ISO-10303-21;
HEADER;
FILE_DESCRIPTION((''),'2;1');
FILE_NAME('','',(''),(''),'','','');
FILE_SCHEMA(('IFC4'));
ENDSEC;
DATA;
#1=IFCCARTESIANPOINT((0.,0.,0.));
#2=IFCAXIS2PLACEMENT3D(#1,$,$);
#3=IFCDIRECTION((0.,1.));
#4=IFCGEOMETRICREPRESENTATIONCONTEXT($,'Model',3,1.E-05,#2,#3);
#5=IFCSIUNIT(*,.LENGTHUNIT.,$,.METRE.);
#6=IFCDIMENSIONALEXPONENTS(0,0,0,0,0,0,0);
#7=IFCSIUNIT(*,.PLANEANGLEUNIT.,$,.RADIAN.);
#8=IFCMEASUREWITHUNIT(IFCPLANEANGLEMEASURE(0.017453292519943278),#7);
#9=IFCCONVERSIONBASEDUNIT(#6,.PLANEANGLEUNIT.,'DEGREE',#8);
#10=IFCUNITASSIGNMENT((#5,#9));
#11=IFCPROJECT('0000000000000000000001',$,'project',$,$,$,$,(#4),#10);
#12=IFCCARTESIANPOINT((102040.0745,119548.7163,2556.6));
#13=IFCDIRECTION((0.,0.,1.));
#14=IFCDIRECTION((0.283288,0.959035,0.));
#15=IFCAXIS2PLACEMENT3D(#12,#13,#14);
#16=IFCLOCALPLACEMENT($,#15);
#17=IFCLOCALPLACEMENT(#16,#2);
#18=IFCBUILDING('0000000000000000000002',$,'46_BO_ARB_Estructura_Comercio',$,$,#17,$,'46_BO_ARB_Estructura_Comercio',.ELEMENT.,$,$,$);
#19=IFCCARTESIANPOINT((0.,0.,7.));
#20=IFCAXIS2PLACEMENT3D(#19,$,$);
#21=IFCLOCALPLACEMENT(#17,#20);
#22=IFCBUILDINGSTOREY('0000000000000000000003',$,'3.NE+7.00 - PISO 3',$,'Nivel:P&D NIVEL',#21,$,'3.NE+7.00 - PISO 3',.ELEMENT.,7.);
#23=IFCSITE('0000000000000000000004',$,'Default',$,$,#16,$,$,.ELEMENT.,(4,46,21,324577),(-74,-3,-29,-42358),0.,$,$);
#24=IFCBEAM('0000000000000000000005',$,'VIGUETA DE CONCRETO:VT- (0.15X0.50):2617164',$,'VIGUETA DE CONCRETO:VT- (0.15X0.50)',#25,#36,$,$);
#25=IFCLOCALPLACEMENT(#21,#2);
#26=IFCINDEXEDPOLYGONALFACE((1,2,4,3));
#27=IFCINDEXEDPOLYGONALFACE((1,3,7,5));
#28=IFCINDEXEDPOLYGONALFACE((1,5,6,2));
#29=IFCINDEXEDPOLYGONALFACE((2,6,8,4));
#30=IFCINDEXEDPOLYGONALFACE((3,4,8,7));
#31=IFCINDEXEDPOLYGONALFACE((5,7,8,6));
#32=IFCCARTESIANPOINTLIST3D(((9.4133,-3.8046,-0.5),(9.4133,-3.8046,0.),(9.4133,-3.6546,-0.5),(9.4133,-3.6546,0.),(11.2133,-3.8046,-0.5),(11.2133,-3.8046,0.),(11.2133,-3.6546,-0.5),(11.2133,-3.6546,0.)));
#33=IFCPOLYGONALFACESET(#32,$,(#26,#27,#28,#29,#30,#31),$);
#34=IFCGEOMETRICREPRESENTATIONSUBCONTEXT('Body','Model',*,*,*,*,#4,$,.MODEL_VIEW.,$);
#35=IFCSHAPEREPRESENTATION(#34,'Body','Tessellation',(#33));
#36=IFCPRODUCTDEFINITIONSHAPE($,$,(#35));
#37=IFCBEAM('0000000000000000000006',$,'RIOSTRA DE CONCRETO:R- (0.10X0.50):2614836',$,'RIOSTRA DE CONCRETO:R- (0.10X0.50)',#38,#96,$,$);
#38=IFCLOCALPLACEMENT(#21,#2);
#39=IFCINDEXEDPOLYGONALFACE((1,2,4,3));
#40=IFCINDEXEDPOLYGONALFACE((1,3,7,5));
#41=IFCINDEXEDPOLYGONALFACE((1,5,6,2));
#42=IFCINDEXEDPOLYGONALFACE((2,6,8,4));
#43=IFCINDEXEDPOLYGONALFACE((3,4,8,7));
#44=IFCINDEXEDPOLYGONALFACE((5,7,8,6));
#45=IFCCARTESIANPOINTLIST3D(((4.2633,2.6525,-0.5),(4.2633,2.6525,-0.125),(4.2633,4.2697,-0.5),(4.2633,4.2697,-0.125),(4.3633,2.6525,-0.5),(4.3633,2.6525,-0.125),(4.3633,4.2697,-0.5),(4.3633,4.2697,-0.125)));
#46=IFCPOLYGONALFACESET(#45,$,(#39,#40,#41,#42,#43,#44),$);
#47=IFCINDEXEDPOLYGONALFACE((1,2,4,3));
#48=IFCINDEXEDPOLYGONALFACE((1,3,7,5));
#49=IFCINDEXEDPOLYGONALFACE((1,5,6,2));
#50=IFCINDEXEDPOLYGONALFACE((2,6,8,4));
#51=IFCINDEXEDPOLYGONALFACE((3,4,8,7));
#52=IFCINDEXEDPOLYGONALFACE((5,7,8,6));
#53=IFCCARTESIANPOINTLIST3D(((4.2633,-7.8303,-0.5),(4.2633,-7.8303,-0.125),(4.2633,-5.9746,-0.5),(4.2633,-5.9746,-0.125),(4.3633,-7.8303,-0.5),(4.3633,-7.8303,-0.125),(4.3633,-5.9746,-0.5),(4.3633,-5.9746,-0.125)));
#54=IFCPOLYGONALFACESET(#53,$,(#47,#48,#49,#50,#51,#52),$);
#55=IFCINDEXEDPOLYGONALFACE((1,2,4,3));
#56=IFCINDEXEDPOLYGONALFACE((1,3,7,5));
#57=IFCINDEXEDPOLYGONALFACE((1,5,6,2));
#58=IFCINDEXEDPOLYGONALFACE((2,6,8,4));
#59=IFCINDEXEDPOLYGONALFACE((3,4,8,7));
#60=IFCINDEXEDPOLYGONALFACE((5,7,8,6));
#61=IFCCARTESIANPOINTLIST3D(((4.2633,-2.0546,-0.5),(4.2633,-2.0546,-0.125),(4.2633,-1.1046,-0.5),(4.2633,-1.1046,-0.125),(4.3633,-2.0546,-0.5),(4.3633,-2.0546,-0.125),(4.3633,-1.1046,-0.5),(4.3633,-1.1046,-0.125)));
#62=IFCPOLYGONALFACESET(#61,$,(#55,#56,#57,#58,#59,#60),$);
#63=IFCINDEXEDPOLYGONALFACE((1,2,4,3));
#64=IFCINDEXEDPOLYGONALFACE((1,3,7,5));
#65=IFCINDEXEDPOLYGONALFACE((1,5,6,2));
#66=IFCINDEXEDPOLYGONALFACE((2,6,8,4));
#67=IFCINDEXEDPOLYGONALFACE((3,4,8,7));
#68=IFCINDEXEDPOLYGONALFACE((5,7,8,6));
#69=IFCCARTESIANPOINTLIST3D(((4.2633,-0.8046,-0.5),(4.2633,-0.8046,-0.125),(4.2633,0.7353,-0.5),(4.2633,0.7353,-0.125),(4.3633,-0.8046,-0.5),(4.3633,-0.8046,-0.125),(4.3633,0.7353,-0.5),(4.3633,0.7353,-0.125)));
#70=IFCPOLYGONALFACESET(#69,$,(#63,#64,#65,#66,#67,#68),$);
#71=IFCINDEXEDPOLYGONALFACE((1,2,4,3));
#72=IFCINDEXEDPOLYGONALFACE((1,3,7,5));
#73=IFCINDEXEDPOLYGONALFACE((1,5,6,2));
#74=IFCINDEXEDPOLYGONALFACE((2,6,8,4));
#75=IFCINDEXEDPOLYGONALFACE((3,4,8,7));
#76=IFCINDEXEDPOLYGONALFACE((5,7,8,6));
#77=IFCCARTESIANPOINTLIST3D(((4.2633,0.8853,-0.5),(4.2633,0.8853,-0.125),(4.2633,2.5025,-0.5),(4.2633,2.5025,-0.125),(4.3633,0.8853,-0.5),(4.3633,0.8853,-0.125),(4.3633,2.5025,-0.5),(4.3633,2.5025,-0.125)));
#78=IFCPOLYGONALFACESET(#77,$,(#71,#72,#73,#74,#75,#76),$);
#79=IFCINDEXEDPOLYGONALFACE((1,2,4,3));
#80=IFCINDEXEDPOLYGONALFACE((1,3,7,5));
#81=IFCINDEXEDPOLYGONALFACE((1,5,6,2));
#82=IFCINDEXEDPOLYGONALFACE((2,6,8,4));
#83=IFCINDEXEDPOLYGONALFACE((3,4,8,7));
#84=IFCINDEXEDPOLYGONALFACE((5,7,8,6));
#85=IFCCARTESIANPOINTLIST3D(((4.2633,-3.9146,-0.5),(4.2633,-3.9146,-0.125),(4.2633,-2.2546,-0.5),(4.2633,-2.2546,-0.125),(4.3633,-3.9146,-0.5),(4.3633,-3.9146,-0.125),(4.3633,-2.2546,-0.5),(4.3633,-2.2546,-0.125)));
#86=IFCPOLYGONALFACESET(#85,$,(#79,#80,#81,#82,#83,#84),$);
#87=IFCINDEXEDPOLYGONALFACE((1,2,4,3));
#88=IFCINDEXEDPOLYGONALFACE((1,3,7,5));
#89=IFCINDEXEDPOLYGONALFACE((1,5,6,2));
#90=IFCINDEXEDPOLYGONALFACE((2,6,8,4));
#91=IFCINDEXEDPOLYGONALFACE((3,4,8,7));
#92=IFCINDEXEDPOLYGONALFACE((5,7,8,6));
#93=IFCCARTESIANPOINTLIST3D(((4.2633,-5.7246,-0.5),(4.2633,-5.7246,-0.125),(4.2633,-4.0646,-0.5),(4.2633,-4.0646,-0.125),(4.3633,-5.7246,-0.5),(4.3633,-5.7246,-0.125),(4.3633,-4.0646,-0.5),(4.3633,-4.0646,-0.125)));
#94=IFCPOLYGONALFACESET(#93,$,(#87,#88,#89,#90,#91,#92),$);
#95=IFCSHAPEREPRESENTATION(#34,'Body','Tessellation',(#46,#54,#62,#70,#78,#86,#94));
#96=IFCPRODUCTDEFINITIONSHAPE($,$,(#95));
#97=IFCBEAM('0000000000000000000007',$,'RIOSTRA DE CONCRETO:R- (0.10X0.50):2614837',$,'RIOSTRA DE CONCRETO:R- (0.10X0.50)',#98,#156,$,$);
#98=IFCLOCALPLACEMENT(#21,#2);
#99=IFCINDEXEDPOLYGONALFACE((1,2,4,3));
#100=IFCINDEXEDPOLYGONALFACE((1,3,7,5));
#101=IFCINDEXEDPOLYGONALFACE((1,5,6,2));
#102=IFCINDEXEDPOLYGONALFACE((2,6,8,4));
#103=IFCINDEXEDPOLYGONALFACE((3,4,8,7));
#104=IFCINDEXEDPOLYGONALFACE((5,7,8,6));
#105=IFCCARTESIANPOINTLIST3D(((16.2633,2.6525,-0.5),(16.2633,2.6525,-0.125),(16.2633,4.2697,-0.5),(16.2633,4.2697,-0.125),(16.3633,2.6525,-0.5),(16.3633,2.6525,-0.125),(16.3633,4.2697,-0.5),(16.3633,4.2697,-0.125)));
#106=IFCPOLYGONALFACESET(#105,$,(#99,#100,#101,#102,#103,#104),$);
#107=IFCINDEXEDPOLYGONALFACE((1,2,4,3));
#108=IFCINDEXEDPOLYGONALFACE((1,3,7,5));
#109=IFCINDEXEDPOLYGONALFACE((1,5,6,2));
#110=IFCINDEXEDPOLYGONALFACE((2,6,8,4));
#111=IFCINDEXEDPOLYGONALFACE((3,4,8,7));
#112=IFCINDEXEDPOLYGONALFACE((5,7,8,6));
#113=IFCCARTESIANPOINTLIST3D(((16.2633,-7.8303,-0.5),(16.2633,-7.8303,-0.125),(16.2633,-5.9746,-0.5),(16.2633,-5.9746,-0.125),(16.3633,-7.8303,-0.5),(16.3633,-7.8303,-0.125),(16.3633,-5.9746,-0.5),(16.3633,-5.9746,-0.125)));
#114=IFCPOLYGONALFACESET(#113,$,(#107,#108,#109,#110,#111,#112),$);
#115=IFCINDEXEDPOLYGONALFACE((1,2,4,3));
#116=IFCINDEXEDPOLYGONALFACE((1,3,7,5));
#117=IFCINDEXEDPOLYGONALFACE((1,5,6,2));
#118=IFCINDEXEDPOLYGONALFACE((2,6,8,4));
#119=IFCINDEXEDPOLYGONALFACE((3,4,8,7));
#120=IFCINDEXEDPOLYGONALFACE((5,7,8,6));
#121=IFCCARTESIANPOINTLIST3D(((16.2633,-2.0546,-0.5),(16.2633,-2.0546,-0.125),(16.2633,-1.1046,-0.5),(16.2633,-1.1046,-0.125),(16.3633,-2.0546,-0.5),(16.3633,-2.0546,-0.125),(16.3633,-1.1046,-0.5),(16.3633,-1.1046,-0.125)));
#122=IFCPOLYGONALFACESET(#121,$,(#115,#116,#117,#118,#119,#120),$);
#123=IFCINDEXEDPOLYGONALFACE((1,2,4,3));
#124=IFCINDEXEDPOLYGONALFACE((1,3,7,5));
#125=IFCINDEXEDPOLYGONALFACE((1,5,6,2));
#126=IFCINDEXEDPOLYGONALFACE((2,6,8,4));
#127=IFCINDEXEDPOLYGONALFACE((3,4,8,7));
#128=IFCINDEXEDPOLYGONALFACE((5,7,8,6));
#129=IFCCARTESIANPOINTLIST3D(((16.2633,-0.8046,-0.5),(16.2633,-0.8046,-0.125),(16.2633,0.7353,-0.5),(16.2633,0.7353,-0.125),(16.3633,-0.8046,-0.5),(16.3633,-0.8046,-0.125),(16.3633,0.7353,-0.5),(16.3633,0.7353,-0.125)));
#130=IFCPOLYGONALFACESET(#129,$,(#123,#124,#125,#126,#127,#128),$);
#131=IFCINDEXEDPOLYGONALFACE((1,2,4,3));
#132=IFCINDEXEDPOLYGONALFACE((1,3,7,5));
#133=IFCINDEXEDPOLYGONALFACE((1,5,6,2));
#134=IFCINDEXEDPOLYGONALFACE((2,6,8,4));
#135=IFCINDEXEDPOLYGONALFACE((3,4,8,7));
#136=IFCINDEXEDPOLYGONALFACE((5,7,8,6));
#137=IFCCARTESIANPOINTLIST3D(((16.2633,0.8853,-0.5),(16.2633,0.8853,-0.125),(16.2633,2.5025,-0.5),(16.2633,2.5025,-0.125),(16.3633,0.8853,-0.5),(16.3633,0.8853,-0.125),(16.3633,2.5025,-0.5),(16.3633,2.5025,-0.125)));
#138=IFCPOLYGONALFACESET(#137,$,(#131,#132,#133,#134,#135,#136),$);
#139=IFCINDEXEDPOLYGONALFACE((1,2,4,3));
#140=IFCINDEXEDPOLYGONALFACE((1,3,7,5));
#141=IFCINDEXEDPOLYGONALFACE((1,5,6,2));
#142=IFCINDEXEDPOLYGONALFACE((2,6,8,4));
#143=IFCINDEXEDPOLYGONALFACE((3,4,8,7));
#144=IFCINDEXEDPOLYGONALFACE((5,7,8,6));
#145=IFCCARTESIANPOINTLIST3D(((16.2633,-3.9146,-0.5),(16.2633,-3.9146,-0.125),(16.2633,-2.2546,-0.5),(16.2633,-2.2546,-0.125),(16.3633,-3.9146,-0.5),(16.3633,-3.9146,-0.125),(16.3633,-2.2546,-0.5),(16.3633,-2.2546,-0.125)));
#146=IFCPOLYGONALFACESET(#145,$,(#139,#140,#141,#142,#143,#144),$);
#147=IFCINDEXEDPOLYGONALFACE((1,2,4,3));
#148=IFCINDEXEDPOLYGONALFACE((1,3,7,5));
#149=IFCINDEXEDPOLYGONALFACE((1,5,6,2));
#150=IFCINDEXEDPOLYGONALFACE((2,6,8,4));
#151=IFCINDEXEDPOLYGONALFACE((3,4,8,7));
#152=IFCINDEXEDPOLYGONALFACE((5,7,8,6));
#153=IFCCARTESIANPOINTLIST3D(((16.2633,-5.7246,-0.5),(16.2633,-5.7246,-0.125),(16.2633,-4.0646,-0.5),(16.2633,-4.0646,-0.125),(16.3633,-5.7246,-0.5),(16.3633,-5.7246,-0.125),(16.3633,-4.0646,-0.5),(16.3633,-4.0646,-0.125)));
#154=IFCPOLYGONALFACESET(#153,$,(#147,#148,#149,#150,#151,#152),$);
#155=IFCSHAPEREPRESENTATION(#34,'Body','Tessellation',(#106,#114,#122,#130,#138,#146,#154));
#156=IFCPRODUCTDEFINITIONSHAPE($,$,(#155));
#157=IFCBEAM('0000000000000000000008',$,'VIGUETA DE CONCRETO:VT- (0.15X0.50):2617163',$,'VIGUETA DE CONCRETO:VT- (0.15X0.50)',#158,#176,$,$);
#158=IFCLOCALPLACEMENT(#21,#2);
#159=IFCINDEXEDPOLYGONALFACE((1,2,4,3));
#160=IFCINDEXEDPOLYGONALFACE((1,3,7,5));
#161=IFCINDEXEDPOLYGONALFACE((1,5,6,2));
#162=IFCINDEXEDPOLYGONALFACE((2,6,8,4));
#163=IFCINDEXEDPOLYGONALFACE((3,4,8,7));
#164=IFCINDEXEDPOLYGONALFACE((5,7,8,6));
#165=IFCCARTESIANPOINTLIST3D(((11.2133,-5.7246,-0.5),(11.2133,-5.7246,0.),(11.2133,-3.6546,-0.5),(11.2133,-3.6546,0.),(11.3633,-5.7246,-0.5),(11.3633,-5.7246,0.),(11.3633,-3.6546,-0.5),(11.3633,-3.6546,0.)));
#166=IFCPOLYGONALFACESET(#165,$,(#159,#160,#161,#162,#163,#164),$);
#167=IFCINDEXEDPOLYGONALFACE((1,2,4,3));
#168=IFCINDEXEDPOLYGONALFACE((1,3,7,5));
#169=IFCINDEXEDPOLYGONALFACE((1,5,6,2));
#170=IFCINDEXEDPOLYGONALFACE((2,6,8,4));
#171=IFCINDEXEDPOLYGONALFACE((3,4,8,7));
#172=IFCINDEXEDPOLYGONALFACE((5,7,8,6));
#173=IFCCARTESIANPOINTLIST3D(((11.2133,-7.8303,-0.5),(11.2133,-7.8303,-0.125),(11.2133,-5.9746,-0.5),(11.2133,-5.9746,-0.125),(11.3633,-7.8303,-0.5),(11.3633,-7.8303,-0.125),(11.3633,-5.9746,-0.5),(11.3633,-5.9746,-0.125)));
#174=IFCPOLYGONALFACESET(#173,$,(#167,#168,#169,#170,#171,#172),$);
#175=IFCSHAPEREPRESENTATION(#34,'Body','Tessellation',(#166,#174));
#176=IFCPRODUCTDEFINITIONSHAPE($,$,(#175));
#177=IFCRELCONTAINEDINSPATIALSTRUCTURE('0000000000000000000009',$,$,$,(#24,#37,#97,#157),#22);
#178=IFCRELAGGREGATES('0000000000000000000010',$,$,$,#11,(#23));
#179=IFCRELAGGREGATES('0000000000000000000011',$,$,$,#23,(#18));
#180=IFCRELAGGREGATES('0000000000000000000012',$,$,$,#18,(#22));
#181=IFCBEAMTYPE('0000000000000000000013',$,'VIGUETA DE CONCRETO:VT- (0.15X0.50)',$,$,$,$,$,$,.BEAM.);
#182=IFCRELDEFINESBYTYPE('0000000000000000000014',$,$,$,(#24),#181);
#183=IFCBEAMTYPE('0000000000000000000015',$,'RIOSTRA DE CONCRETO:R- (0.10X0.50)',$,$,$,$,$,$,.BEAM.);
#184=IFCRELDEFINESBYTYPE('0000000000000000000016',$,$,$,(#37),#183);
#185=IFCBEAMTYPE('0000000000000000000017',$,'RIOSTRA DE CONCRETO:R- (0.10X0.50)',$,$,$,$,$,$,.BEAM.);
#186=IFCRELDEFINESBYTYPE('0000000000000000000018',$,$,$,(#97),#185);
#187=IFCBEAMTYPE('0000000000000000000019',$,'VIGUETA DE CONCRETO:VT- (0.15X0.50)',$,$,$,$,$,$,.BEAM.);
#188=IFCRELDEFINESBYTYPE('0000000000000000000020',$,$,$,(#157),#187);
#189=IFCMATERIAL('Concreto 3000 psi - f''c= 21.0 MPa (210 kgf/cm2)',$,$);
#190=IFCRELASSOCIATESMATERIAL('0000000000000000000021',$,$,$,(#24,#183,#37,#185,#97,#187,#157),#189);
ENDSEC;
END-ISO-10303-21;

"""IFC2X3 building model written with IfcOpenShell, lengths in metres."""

from ifc_helpers import new_model, entity, si_unit, converted_unit, direction, frame, frame_2d, origin, origin_2d_with_axis, place, context, subcontext, project, spatial, rectangle, extrude, source, transform, mapped, material, type_object, type_shapes, element, save


model = new_model("IFC2X3")

# Units and contexts
model_context = context("Model", 3, precision=1e-05, world=origin(), true_north=direction((0.0, 1.0)))
body_context = subcontext(model_context, "Body", "Model", "MODEL_VIEW")
ifc_project = project(units=[si_unit("LENGTHUNIT", "METRE"), converted_unit("PLANEANGLEUNIT", "DEGREE", entity("IfcPlaneAngleMeasure", 0.017453292519943278), si_unit("PLANEANGLEUNIT", "RADIAN"), dimensions=[0, 0, 0, 0, 0, 0, 0])], contexts=[model_context])

# Site, building, storey
site_placement = place(None, frame((102040.0745, 119548.7163, 2556.6), z_axis=(0.0, 0.0, 1.0), x_axis=(0.283288, 0.959035, 0.0)))
site = spatial("IfcSite", under=ifc_project, at=site_placement, Name="Default", CompositionType="ELEMENT", RefLatitude=(4, 46, 21, 324577), RefLongitude=(-74, -3, -29, -42358), RefElevation=0.0)
building_placement = place(site_placement, origin())
building = spatial("IfcBuilding", under=site, at=building_placement, Name="46_BO_ARB_Estructura_Comercio", LongName="46_BO_ARB_Estructura_Comercio", CompositionType="ELEMENT")
storey_placement = place(building_placement, frame((0.0, 0.0, 7.0)))
storey = spatial("IfcBuildingStorey", under=building, at=storey_placement, Name="3.NE+7.00 - PISO 3", ObjectType="Nivel:P&D NIVEL", LongName="3.NE+7.00 - PISO 3", CompositionType="ELEMENT", Elevation=7.0)

# Beams
ifc_material = material(Name="Concreto 3000 psi - f'c= 21.0 MPa (210 kgf/cm2)")
beam_type_1 = type_object("IfcBeamType", Name="VIGUETA DE CONCRETO:VT- (0.15X0.50)", PredefinedType="BEAM")
beam_1_placement = place(storey_placement, frame((11.2883, -3.7296, 0.0), z_axis=(0.0, 0.0, 1.0), x_axis=(-1.0, 0.0, 0.0)))
element("IfcBeam", 1, at=beam_1_placement, inside=storey, type_object=beam_type_1, material=ifc_material, Name="VIGUETA DE CONCRETO:VT- (0.15X0.50):2617164", ObjectType="VIGUETA DE CONCRETO:VT- (0.15X0.50)", context=body_context, shape_type="SweptSolid", body=[
    extrude(rectangle(XDim=0.5, YDim=0.15, at=origin_2d_with_axis()), frame((0.075, 0.0, -0.25), z_axis=(1.0, 0.0, 0.0), x_axis=(0.0, 0.0, -1.0)), (0.0, 0.0, 1.0), 1.8),
])
beam_type_2 = type_object("IfcBeamType", Name="RIOSTRA DE CONCRETO:R- (0.10X0.50)", PredefinedType="BEAM", material=ifc_material)
shared_shape_1 = source(origin(), body_context, "Body", "SweptSolid", [
    extrude(rectangle(XDim=0.375, YDim=0.1, at=frame_2d((0.0, 0.0), x_axis=(0.0, 1.0))), frame((4.3133, 2.6525, 6.6875), z_axis=(0.0, 1.0, 0.0), x_axis=(-1.0, 0.0, 0.0)), (0.0, 0.0, 1.0), 1.6172),
    extrude(rectangle(XDim=0.375, YDim=0.1, at=frame_2d((0.0, 0.0), x_axis=(0.0, 1.0))), frame((4.3133, -7.8303, 6.6875), z_axis=(0.0, 1.0, 0.0), x_axis=(-1.0, 0.0, 0.0)), (0.0, 0.0, 1.0), 1.8557),
    extrude(rectangle(XDim=0.375, YDim=0.1, at=frame_2d((0.0, 0.0), x_axis=(0.0, 1.0))), frame((4.3133, -2.0546, 6.6875), z_axis=(0.0, 1.0, 0.0), x_axis=(-1.0, 0.0, 0.0)), (0.0, 0.0, 1.0), 0.95),
    extrude(rectangle(XDim=0.375, YDim=0.1, at=frame_2d((0.0, 0.0), x_axis=(0.0, 1.0))), frame((4.3133, -0.8046, 6.6875), z_axis=(0.0, 1.0, 0.0), x_axis=(-1.0, 0.0, 0.0)), (0.0, 0.0, 1.0), 1.5399),
    extrude(rectangle(XDim=0.375, YDim=0.1, at=frame_2d((0.0, 0.0), x_axis=(0.0, 1.0))), frame((4.3133, 0.8853, 6.6875), z_axis=(0.0, 1.0, 0.0), x_axis=(-1.0, 0.0, 0.0)), (0.0, 0.0, 1.0), 1.6172),
    extrude(rectangle(XDim=0.375, YDim=0.1, at=frame_2d((0.0, 0.0), x_axis=(0.0, 1.0))), frame((4.3133, -3.9146, 6.6875), z_axis=(0.0, 1.0, 0.0), x_axis=(-1.0, 0.0, 0.0)), (0.0, 0.0, 1.0), 1.66),
    extrude(rectangle(XDim=0.375, YDim=0.1, at=frame_2d((0.0, 0.0), x_axis=(0.0, 1.0))), frame((4.3133, -5.7246, 6.6875), z_axis=(0.0, 1.0, 0.0), x_axis=(-1.0, 0.0, 0.0)), (0.0, 0.0, 1.0), 1.66),
])
type_shapes(beam_type_2, [shared_shape_1])
beam_2_placement = place(storey_placement, frame((0.0, 0.0, -7.0)))
element("IfcBeam", 2, at=beam_2_placement, inside=storey, type_object=beam_type_2, material=ifc_material, Name="RIOSTRA DE CONCRETO:R- (0.10X0.50):2614836", ObjectType="RIOSTRA DE CONCRETO:R- (0.10X0.50)", context=body_context, shape_type="MappedRepresentation", body=[
    mapped(shared_shape_1, transform((0.0, 0.0, 0.0), scale=1.0)),
])
beam_type_3 = type_object("IfcBeamType", Name="RIOSTRA DE CONCRETO:R- (0.10X0.50)", PredefinedType="BEAM", material=ifc_material)
shared_shape_2 = source(origin(), body_context, "Body", "SweptSolid", [
    extrude(rectangle(XDim=0.375, YDim=0.1, at=frame_2d((0.0, 0.0), x_axis=(0.0, 1.0))), frame((16.3133, 2.6525, 6.6875), z_axis=(0.0, 1.0, 0.0), x_axis=(-1.0, 0.0, 0.0)), (0.0, 0.0, 1.0), 1.6172),
    extrude(rectangle(XDim=0.375, YDim=0.1, at=frame_2d((0.0, 0.0), x_axis=(0.0, 1.0))), frame((16.3133, -7.8303, 6.6875), z_axis=(0.0, 1.0, 0.0), x_axis=(-1.0, 0.0, 0.0)), (0.0, 0.0, 1.0), 1.8557),
    extrude(rectangle(XDim=0.375, YDim=0.1, at=frame_2d((0.0, 0.0), x_axis=(0.0, 1.0))), frame((16.3133, -2.0546, 6.6875), z_axis=(0.0, 1.0, 0.0), x_axis=(-1.0, 0.0, 0.0)), (0.0, 0.0, 1.0), 0.95),
    extrude(rectangle(XDim=0.375, YDim=0.1, at=frame_2d((0.0, 0.0), x_axis=(0.0, 1.0))), frame((16.3133, -0.8046, 6.6875), z_axis=(0.0, 1.0, 0.0), x_axis=(-1.0, 0.0, 0.0)), (0.0, 0.0, 1.0), 1.5399),
    extrude(rectangle(XDim=0.375, YDim=0.1, at=frame_2d((0.0, 0.0), x_axis=(0.0, 1.0))), frame((16.3133, 0.8853, 6.6875), z_axis=(0.0, 1.0, 0.0), x_axis=(-1.0, 0.0, 0.0)), (0.0, 0.0, 1.0), 1.6172),
    extrude(rectangle(XDim=0.375, YDim=0.1, at=frame_2d((0.0, 0.0), x_axis=(0.0, 1.0))), frame((16.3133, -3.9146, 6.6875), z_axis=(0.0, 1.0, 0.0), x_axis=(-1.0, 0.0, 0.0)), (0.0, 0.0, 1.0), 1.66),
    extrude(rectangle(XDim=0.375, YDim=0.1, at=frame_2d((0.0, 0.0), x_axis=(0.0, 1.0))), frame((16.3133, -5.7246, 6.6875), z_axis=(0.0, 1.0, 0.0), x_axis=(-1.0, 0.0, 0.0)), (0.0, 0.0, 1.0), 1.66),
])
type_shapes(beam_type_3, [shared_shape_2])
beam_3_placement = place(storey_placement, frame((0.0, 0.0, -7.0)))
element("IfcBeam", 3, at=beam_3_placement, inside=storey, type_object=beam_type_3, material=ifc_material, Name="RIOSTRA DE CONCRETO:R- (0.10X0.50):2614837", ObjectType="RIOSTRA DE CONCRETO:R- (0.10X0.50)", context=body_context, shape_type="MappedRepresentation", body=[
    mapped(shared_shape_2, transform((0.0, 0.0, 0.0), scale=1.0)),
])
beam_type_4 = type_object("IfcBeamType", Name="VIGUETA DE CONCRETO:VT- (0.15X0.50)", PredefinedType="BEAM", material=ifc_material)
shared_shape_3 = source(origin(), body_context, "Body", "SweptSolid", [
    extrude(rectangle(XDim=0.5, YDim=0.15, at=frame_2d((0.0, 0.0), x_axis=(0.0, 1.0))), frame((11.2883, -3.6546, 6.75), z_axis=(0.0, -1.0, 0.0), x_axis=(-1.0, 0.0, 0.0)), (0.0, 0.0, 1.0), 2.07),
    extrude(rectangle(XDim=0.375, YDim=0.15, at=frame_2d((0.0, 0.0), x_axis=(0.0, 1.0))), frame((11.2883, -5.9746, 6.6875), z_axis=(0.0, -1.0, 0.0), x_axis=(-1.0, 0.0, 0.0)), (0.0, 0.0, 1.0), 1.8557),
])
type_shapes(beam_type_4, [shared_shape_3])
beam_4_placement = place(storey_placement, frame((0.0, 0.0, -7.0)))
element("IfcBeam", 4, at=beam_4_placement, inside=storey, type_object=beam_type_4, material=ifc_material, Name="VIGUETA DE CONCRETO:VT- (0.15X0.50):2617163", ObjectType="VIGUETA DE CONCRETO:VT- (0.15X0.50)", context=body_context, shape_type="MappedRepresentation", body=[
    mapped(shared_shape_3, transform((0.0, 0.0, 0.0), scale=1.0)),
])

save(model, "model.ifc")
